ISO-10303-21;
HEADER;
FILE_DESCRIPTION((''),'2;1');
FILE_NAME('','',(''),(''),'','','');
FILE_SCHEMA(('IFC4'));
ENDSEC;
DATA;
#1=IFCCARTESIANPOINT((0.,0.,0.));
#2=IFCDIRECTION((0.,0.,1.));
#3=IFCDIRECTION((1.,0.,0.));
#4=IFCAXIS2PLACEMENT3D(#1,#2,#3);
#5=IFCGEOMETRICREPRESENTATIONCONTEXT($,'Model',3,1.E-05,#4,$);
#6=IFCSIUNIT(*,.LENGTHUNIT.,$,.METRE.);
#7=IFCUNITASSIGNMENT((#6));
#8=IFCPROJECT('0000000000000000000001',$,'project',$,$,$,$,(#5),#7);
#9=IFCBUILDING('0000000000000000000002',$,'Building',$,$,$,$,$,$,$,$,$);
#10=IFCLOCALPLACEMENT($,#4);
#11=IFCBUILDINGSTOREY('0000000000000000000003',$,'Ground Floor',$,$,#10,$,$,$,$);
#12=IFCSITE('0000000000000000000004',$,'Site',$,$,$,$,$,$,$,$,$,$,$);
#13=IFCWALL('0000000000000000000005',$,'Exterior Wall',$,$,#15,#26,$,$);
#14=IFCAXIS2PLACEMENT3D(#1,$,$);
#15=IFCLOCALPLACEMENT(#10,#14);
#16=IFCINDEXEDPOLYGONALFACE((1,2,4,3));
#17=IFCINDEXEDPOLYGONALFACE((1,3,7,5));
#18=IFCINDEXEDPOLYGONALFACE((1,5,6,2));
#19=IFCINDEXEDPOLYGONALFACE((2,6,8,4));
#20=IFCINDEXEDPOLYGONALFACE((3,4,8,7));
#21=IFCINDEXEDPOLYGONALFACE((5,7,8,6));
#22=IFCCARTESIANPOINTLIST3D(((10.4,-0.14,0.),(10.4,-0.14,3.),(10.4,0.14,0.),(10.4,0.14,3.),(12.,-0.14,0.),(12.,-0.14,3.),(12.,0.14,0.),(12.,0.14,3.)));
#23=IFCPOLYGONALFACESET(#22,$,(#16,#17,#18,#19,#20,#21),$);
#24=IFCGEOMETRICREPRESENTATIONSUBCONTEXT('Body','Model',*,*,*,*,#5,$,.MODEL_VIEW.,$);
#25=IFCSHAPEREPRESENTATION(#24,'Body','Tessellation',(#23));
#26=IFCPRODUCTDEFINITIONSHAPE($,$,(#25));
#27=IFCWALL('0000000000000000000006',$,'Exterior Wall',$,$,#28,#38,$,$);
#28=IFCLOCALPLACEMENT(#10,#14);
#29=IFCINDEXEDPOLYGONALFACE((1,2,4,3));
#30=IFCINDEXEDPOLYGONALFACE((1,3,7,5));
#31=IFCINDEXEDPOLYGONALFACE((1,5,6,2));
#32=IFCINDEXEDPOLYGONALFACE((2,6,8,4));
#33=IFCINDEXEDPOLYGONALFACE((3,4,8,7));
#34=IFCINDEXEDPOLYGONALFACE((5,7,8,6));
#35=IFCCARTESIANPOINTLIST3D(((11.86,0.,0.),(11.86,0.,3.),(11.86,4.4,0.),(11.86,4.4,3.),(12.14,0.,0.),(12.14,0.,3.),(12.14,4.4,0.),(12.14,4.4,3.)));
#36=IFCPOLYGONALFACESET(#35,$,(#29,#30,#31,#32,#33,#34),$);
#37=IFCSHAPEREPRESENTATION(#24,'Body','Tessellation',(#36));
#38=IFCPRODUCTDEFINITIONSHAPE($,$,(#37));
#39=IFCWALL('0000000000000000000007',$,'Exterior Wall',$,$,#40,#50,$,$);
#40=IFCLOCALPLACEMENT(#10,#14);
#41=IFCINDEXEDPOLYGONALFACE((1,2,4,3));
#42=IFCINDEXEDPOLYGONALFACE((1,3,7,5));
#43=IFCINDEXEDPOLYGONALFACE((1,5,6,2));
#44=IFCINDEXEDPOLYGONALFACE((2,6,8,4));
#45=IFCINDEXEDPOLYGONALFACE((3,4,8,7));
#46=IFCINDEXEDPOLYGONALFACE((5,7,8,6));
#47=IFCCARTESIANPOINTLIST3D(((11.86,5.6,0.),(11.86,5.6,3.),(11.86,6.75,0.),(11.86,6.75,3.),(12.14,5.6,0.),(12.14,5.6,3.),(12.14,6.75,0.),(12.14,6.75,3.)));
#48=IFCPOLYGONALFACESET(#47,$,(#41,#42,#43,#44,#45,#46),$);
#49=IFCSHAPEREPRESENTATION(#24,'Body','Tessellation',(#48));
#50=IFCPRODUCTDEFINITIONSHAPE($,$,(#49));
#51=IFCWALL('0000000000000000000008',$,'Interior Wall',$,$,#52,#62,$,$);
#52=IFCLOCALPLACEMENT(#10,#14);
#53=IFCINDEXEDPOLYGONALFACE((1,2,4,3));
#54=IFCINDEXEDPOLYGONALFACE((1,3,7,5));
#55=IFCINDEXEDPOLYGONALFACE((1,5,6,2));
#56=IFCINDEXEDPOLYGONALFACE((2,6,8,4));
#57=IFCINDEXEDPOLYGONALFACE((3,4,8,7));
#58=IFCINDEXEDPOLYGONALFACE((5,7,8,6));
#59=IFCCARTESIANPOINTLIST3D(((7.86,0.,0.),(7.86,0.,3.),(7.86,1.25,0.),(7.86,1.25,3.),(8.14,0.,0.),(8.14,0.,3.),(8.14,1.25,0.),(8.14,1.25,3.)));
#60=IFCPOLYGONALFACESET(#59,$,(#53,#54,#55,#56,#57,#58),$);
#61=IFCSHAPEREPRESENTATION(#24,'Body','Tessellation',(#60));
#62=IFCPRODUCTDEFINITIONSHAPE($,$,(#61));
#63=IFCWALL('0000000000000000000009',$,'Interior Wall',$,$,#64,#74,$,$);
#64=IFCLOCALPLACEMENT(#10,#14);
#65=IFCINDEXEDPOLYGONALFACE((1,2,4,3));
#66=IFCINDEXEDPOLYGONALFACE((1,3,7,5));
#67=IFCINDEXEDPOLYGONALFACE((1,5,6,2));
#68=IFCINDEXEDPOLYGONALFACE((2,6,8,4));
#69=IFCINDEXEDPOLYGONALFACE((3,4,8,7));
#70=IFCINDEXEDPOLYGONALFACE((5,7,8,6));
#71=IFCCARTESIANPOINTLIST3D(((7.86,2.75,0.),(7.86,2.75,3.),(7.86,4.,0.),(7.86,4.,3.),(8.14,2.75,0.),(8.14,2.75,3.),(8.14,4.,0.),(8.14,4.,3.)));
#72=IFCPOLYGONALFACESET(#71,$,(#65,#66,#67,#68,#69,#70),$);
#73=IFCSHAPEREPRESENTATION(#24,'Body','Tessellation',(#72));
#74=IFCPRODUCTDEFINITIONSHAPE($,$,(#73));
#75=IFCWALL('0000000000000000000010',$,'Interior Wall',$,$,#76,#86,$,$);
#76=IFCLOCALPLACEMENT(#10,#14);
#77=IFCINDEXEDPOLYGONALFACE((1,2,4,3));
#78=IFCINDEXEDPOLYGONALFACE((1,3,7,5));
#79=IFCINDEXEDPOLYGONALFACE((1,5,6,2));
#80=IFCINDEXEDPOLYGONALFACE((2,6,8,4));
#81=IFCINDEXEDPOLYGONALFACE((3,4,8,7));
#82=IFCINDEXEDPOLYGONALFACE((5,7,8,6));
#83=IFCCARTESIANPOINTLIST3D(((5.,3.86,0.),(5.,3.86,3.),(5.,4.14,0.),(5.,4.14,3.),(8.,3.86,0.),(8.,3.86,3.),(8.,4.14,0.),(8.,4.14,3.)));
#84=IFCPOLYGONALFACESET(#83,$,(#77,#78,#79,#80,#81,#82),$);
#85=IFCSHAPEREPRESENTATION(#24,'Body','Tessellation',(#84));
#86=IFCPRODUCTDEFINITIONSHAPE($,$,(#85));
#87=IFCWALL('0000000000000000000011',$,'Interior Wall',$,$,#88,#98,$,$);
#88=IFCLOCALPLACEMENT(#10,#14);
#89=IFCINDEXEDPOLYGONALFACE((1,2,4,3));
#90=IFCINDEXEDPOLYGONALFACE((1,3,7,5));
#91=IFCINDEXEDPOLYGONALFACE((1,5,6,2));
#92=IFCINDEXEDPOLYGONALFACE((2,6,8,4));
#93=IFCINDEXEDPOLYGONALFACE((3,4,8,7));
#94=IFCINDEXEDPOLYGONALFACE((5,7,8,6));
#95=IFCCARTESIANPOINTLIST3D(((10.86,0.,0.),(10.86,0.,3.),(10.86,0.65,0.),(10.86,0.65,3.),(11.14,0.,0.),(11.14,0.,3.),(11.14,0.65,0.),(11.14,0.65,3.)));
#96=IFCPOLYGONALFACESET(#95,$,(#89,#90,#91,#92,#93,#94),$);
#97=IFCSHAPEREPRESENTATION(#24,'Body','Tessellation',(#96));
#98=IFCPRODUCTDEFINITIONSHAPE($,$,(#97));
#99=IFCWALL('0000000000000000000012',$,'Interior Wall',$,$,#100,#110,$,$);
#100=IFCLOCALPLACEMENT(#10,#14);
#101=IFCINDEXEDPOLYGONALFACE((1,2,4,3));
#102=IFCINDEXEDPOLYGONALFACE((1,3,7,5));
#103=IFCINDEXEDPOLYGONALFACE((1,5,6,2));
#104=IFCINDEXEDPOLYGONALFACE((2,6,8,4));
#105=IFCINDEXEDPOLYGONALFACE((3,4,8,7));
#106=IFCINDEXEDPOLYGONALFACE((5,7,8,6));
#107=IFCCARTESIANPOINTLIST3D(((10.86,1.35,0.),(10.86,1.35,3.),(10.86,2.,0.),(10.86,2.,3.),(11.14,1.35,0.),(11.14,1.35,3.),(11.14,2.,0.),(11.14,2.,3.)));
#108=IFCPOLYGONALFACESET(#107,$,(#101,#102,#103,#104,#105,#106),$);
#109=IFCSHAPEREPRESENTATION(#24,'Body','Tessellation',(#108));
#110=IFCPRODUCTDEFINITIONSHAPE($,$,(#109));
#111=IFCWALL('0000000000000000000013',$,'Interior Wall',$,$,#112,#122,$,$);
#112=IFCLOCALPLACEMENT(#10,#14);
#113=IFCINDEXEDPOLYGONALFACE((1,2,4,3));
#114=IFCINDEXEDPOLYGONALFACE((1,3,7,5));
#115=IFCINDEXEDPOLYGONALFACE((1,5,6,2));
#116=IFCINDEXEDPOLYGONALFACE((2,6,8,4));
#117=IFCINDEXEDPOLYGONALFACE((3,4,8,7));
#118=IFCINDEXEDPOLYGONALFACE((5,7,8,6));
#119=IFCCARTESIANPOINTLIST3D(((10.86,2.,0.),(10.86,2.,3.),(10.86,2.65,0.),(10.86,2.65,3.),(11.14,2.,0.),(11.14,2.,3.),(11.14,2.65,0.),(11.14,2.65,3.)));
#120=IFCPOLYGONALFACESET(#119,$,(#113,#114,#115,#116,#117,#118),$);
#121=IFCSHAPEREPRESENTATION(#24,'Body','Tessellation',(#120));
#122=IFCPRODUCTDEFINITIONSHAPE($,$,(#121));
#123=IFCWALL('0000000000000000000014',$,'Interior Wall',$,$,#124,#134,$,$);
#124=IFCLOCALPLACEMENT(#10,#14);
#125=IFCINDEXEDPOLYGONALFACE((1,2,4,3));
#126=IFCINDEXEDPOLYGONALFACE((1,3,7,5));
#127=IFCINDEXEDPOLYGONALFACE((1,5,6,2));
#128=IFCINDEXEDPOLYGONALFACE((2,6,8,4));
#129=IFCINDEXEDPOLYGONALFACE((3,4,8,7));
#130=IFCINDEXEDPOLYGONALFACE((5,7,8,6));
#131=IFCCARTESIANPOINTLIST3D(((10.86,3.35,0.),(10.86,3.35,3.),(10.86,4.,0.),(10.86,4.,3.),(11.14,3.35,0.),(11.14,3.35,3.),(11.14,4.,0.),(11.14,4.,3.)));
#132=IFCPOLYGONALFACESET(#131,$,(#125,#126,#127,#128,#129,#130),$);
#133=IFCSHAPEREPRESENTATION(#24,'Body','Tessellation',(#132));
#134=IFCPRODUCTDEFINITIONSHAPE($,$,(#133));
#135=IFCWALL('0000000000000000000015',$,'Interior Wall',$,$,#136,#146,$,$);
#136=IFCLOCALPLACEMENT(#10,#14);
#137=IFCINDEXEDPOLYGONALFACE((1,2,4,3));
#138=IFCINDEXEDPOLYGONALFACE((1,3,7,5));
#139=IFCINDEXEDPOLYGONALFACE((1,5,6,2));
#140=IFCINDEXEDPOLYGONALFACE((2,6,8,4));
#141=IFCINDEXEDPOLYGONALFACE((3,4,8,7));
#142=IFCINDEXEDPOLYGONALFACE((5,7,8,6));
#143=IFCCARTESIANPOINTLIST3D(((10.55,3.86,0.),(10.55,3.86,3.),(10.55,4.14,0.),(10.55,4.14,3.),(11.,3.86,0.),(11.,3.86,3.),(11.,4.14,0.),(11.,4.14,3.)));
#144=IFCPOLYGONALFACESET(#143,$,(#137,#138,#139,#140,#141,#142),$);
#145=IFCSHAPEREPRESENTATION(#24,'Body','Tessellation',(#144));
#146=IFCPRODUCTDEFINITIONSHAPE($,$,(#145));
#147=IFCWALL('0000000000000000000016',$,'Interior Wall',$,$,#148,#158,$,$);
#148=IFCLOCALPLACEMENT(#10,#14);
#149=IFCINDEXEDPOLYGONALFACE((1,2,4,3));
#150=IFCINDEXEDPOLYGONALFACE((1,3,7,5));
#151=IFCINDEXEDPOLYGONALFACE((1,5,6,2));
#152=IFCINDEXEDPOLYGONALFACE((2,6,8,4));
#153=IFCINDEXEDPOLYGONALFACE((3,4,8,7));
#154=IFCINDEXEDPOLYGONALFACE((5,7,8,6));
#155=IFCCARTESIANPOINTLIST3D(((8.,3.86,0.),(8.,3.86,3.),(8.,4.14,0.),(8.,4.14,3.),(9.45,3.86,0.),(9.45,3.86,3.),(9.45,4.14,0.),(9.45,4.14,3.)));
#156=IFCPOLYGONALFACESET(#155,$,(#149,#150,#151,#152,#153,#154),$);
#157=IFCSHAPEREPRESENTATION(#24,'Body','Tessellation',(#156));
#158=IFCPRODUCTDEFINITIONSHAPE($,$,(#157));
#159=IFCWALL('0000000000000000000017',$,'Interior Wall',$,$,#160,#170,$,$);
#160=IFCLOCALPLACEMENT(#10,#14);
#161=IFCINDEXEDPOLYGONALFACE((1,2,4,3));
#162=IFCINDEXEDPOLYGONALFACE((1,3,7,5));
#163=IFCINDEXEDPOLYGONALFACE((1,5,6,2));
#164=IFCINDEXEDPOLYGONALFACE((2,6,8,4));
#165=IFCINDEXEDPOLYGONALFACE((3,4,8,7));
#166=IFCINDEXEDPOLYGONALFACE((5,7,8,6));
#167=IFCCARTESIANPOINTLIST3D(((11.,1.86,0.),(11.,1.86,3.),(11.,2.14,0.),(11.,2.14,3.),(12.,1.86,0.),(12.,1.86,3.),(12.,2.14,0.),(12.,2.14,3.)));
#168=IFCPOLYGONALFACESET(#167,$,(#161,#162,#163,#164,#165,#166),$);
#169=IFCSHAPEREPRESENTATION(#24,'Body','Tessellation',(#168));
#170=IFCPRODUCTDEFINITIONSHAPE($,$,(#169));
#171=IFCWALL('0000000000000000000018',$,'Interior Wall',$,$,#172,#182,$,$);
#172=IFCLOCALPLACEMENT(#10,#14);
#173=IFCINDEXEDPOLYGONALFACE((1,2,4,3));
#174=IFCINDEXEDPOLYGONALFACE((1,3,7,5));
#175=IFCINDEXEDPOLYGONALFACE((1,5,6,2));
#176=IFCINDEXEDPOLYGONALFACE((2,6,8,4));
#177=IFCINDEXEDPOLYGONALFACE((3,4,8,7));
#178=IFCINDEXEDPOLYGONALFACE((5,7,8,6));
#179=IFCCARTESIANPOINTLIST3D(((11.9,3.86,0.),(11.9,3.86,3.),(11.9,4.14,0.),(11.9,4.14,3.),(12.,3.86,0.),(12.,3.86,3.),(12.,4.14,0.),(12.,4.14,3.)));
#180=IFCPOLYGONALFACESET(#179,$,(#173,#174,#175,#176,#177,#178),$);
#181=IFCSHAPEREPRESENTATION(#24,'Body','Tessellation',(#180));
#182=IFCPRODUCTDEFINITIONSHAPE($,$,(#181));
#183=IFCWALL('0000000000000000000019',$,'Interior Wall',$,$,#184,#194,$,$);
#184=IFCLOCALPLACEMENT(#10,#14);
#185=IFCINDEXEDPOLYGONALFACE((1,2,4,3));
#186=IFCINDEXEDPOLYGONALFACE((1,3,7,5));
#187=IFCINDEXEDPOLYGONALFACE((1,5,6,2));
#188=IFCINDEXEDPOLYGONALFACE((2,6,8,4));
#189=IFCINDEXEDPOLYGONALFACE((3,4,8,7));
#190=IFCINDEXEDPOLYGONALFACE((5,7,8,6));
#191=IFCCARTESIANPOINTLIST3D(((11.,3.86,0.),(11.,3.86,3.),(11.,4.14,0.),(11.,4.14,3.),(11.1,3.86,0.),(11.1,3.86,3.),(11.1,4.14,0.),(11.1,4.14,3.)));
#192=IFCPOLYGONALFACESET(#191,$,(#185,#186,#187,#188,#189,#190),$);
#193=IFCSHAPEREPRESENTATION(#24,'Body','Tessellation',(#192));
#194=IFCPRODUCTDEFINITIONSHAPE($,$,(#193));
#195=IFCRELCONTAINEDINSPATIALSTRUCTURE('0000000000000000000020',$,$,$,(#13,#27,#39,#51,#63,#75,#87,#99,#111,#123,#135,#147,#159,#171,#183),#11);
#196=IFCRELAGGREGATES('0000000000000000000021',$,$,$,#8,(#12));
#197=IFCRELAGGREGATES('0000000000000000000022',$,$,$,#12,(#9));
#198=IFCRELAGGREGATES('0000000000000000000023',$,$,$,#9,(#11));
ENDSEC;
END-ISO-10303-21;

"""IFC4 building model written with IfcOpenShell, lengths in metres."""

from ifc_helpers import new_model, si_unit, frame, origin_with_axes, place, context, subcontext, project, spatial, indexed_curve, outline, extrude, element, save


model = new_model("IFC4")

# Units and contexts
model_context = context("Model", 3, precision=1e-05, world=origin_with_axes())
body_context = subcontext(model_context, "Body", "Model", "MODEL_VIEW")
ifc_project = project(units=[si_unit("LENGTHUNIT", "METRE")], contexts=[model_context])

# Site, building, storey
site = spatial("IfcSite", under=ifc_project, Name="Site")
building = spatial("IfcBuilding", under=site, Name="Building")
storey_placement = place(None, origin_with_axes())
storey = spatial("IfcBuildingStorey", under=building, at=storey_placement, Name="Ground Floor")

# Walls
wall_1_placement = place(storey_placement, frame((10.4, 0.0, 0.0), z_axis=(0.0, 0.0, 1.0), x_axis=(1.0, 0.0, 0.0)))
element("IfcWall", 1, at=wall_1_placement, inside=storey, Name="Exterior Wall", context=body_context, shape_type="SweptSolid", body=[
    extrude(outline(indexed_curve([(0.0, 0.0), (0.0, 0.28), (1.6, 0.28), (1.6, 0.0), (0.0, 0.0)], self_intersect=False)), frame((0.0, -0.14, 0.0), z_axis=(0.0, 0.0, 1.0), x_axis=(1.0, 0.0, 0.0)), (0.0, 0.0, 1.0), 3.0),
])
wall_2_placement = place(storey_placement, frame((12.0, 0.0, 0.0), z_axis=(0.0, 0.0, 1.0), x_axis=(0.0, 1.0, 0.0)))
element("IfcWall", 2, at=wall_2_placement, inside=storey, Name="Exterior Wall", context=body_context, shape_type="SweptSolid", body=[
    extrude(outline(indexed_curve([(0.0, 0.0), (0.0, 0.28), (4.4, 0.28), (4.4, 0.0), (0.0, 0.0)], self_intersect=False)), frame((0.0, -0.14, 0.0), z_axis=(0.0, 0.0, 1.0), x_axis=(1.0, 0.0, 0.0)), (0.0, 0.0, 1.0), 3.0),
])
wall_3_placement = place(storey_placement, frame((12.0, 5.6, 0.0), z_axis=(0.0, 0.0, 1.0), x_axis=(0.0, 1.0, 0.0)))
element("IfcWall", 3, at=wall_3_placement, inside=storey, Name="Exterior Wall", context=body_context, shape_type="SweptSolid", body=[
    extrude(outline(indexed_curve([(0.0, 0.0), (0.0, 0.28), (1.15, 0.28), (1.15, 0.0), (0.0, 0.0)], self_intersect=False)), frame((0.0, -0.14, 0.0), z_axis=(0.0, 0.0, 1.0), x_axis=(1.0, 0.0, 0.0)), (0.0, 0.0, 1.0), 3.0),
])
for number, where, z_axis, x_axis, name in (
    (4, (8.0, 0.0, 0.0), (0.0, 0.0, 1.0), (0.0, 1.0, 0.0), "Interior Wall"),
    (5, (8.0, 2.75, 0.0), (0.0, 0.0, 1.0), (0.0, 1.0, 0.0), "Interior Wall"),
):
    element("IfcWall", number, at=place(storey_placement, frame(where, z_axis=z_axis, x_axis=x_axis)), inside=storey, Name=name, context=body_context, shape_type="SweptSolid", body=[
        extrude(outline(indexed_curve([(0.0, 0.0), (0.0, 0.28), (1.25, 0.28), (1.25, 0.0), (0.0, 0.0)], self_intersect=False)), frame((0.0, -0.14, 0.0), z_axis=(0.0, 0.0, 1.0), x_axis=(1.0, 0.0, 0.0)), (0.0, 0.0, 1.0), 3.0),
    ])
wall_4_placement = place(storey_placement, frame((8.0, 4.0, 0.0), z_axis=(0.0, 0.0, 1.0), x_axis=(-1.0, 0.0, 0.0)))
element("IfcWall", 6, at=wall_4_placement, inside=storey, Name="Interior Wall", context=body_context, shape_type="SweptSolid", body=[
    extrude(outline(indexed_curve([(0.0, 0.0), (0.0, 0.28), (3.0, 0.28), (3.0, 0.0), (0.0, 0.0)], self_intersect=False)), frame((0.0, -0.14, 0.0), z_axis=(0.0, 0.0, 1.0), x_axis=(1.0, 0.0, 0.0)), (0.0, 0.0, 1.0), 3.0),
])
wall_5_placement = place(storey_placement, frame((11.0, 0.0, 0.0), z_axis=(0.0, 0.0, 1.0), x_axis=(0.0, 1.0, 0.0)))
element("IfcWall", 7, at=wall_5_placement, inside=storey, Name="Interior Wall", context=body_context, shape_type="SweptSolid", body=[
    extrude(outline(indexed_curve([(0.0, 0.0), (0.0, 0.28), (0.65, 0.28), (0.65, 0.0), (0.0, 0.0)], self_intersect=False)), frame((0.0, -0.14, 0.0), z_axis=(0.0, 0.0, 1.0), x_axis=(1.0, 0.0, 0.0)), (0.0, 0.0, 1.0), 3.0),
])
for number, where, z_axis, x_axis, name in (
    (8, (11.0, 1.35, 0.0), (0.0, 0.0, 1.0), (0.0, 1.0, 0.0), "Interior Wall"),
    (9, (11.0, 2.0, 0.0), (0.0, 0.0, 1.0), (0.0, 1.0, 0.0), "Interior Wall"),
    (10, (11.0, 3.35, 0.0), (0.0, 0.0, 1.0), (0.0, 1.0, 0.0), "Interior Wall"),
):
    element("IfcWall", number, at=place(storey_placement, frame(where, z_axis=z_axis, x_axis=x_axis)), inside=storey, Name=name, context=body_context, shape_type="SweptSolid", body=[
        extrude(outline(indexed_curve([(0.0, 0.0), (0.0, 0.28), (0.65, 0.28), (0.65, 0.0), (0.0, 0.0)], self_intersect=False)), frame((0.0, -0.14, 0.0), z_axis=(0.0, 0.0, 1.0), x_axis=(1.0, 0.0, 0.0)), (0.0, 0.0, 1.0), 3.0),
    ])
wall_6_placement = place(storey_placement, frame((11.0, 4.0, 0.0), z_axis=(0.0, 0.0, 1.0), x_axis=(-1.0, 0.0, 0.0)))
element("IfcWall", 11, at=wall_6_placement, inside=storey, Name="Interior Wall", context=body_context, shape_type="SweptSolid", body=[
    extrude(outline(indexed_curve([(0.0, 0.0), (0.0, 0.28), (0.45, 0.28), (0.45, 0.0), (0.0, 0.0)], self_intersect=False)), frame((0.0, -0.14, 0.0), z_axis=(0.0, 0.0, 1.0), x_axis=(1.0, 0.0, 0.0)), (0.0, 0.0, 1.0), 3.0),
])
wall_7_placement = place(storey_placement, frame((9.45, 4.0, 0.0), z_axis=(0.0, 0.0, 1.0), x_axis=(-1.0, 0.0, 0.0)))
element("IfcWall", 12, at=wall_7_placement, inside=storey, Name="Interior Wall", context=body_context, shape_type="SweptSolid", body=[
    extrude(outline(indexed_curve([(0.0, 0.0), (0.0, 0.28), (1.45, 0.28), (1.45, 0.0), (0.0, 0.0)], self_intersect=False)), frame((0.0, -0.14, 0.0), z_axis=(0.0, 0.0, 1.0), x_axis=(1.0, 0.0, 0.0)), (0.0, 0.0, 1.0), 3.0),
])
wall_8_placement = place(storey_placement, frame((12.0, 2.0, 0.0), z_axis=(0.0, 0.0, 1.0), x_axis=(-1.0, 0.0, 0.0)))
element("IfcWall", 13, at=wall_8_placement, inside=storey, Name="Interior Wall", context=body_context, shape_type="SweptSolid", body=[
    extrude(outline(indexed_curve([(0.0, 0.0), (0.0, 0.28), (1.0, 0.28), (1.0, 0.0), (0.0, 0.0)], self_intersect=False)), frame((0.0, -0.14, 0.0), z_axis=(0.0, 0.0, 1.0), x_axis=(1.0, 0.0, 0.0)), (0.0, 0.0, 1.0), 3.0),
])
for number, where, z_axis, x_axis, name in (
    (14, (12.0, 4.0, 0.0), (0.0, 0.0, 1.0), (-1.0, 0.0, 0.0), "Interior Wall"),
    (15, (11.1, 4.0, 0.0), (0.0, 0.0, 1.0), (-1.0, 0.0, 0.0), "Interior Wall"),
):
    element("IfcWall", number, at=place(storey_placement, frame(where, z_axis=z_axis, x_axis=x_axis)), inside=storey, Name=name, context=body_context, shape_type="SweptSolid", body=[
        extrude(outline(indexed_curve([(0.0, 0.0), (0.0, 0.28), (0.1, 0.28), (0.1, 0.0), (0.0, 0.0)], self_intersect=False)), frame((0.0, -0.14, 0.0), z_axis=(0.0, 0.0, 1.0), x_axis=(1.0, 0.0, 0.0)), (0.0, 0.0, 1.0), 3.0),
    ])

save(model, "model.ifc")
